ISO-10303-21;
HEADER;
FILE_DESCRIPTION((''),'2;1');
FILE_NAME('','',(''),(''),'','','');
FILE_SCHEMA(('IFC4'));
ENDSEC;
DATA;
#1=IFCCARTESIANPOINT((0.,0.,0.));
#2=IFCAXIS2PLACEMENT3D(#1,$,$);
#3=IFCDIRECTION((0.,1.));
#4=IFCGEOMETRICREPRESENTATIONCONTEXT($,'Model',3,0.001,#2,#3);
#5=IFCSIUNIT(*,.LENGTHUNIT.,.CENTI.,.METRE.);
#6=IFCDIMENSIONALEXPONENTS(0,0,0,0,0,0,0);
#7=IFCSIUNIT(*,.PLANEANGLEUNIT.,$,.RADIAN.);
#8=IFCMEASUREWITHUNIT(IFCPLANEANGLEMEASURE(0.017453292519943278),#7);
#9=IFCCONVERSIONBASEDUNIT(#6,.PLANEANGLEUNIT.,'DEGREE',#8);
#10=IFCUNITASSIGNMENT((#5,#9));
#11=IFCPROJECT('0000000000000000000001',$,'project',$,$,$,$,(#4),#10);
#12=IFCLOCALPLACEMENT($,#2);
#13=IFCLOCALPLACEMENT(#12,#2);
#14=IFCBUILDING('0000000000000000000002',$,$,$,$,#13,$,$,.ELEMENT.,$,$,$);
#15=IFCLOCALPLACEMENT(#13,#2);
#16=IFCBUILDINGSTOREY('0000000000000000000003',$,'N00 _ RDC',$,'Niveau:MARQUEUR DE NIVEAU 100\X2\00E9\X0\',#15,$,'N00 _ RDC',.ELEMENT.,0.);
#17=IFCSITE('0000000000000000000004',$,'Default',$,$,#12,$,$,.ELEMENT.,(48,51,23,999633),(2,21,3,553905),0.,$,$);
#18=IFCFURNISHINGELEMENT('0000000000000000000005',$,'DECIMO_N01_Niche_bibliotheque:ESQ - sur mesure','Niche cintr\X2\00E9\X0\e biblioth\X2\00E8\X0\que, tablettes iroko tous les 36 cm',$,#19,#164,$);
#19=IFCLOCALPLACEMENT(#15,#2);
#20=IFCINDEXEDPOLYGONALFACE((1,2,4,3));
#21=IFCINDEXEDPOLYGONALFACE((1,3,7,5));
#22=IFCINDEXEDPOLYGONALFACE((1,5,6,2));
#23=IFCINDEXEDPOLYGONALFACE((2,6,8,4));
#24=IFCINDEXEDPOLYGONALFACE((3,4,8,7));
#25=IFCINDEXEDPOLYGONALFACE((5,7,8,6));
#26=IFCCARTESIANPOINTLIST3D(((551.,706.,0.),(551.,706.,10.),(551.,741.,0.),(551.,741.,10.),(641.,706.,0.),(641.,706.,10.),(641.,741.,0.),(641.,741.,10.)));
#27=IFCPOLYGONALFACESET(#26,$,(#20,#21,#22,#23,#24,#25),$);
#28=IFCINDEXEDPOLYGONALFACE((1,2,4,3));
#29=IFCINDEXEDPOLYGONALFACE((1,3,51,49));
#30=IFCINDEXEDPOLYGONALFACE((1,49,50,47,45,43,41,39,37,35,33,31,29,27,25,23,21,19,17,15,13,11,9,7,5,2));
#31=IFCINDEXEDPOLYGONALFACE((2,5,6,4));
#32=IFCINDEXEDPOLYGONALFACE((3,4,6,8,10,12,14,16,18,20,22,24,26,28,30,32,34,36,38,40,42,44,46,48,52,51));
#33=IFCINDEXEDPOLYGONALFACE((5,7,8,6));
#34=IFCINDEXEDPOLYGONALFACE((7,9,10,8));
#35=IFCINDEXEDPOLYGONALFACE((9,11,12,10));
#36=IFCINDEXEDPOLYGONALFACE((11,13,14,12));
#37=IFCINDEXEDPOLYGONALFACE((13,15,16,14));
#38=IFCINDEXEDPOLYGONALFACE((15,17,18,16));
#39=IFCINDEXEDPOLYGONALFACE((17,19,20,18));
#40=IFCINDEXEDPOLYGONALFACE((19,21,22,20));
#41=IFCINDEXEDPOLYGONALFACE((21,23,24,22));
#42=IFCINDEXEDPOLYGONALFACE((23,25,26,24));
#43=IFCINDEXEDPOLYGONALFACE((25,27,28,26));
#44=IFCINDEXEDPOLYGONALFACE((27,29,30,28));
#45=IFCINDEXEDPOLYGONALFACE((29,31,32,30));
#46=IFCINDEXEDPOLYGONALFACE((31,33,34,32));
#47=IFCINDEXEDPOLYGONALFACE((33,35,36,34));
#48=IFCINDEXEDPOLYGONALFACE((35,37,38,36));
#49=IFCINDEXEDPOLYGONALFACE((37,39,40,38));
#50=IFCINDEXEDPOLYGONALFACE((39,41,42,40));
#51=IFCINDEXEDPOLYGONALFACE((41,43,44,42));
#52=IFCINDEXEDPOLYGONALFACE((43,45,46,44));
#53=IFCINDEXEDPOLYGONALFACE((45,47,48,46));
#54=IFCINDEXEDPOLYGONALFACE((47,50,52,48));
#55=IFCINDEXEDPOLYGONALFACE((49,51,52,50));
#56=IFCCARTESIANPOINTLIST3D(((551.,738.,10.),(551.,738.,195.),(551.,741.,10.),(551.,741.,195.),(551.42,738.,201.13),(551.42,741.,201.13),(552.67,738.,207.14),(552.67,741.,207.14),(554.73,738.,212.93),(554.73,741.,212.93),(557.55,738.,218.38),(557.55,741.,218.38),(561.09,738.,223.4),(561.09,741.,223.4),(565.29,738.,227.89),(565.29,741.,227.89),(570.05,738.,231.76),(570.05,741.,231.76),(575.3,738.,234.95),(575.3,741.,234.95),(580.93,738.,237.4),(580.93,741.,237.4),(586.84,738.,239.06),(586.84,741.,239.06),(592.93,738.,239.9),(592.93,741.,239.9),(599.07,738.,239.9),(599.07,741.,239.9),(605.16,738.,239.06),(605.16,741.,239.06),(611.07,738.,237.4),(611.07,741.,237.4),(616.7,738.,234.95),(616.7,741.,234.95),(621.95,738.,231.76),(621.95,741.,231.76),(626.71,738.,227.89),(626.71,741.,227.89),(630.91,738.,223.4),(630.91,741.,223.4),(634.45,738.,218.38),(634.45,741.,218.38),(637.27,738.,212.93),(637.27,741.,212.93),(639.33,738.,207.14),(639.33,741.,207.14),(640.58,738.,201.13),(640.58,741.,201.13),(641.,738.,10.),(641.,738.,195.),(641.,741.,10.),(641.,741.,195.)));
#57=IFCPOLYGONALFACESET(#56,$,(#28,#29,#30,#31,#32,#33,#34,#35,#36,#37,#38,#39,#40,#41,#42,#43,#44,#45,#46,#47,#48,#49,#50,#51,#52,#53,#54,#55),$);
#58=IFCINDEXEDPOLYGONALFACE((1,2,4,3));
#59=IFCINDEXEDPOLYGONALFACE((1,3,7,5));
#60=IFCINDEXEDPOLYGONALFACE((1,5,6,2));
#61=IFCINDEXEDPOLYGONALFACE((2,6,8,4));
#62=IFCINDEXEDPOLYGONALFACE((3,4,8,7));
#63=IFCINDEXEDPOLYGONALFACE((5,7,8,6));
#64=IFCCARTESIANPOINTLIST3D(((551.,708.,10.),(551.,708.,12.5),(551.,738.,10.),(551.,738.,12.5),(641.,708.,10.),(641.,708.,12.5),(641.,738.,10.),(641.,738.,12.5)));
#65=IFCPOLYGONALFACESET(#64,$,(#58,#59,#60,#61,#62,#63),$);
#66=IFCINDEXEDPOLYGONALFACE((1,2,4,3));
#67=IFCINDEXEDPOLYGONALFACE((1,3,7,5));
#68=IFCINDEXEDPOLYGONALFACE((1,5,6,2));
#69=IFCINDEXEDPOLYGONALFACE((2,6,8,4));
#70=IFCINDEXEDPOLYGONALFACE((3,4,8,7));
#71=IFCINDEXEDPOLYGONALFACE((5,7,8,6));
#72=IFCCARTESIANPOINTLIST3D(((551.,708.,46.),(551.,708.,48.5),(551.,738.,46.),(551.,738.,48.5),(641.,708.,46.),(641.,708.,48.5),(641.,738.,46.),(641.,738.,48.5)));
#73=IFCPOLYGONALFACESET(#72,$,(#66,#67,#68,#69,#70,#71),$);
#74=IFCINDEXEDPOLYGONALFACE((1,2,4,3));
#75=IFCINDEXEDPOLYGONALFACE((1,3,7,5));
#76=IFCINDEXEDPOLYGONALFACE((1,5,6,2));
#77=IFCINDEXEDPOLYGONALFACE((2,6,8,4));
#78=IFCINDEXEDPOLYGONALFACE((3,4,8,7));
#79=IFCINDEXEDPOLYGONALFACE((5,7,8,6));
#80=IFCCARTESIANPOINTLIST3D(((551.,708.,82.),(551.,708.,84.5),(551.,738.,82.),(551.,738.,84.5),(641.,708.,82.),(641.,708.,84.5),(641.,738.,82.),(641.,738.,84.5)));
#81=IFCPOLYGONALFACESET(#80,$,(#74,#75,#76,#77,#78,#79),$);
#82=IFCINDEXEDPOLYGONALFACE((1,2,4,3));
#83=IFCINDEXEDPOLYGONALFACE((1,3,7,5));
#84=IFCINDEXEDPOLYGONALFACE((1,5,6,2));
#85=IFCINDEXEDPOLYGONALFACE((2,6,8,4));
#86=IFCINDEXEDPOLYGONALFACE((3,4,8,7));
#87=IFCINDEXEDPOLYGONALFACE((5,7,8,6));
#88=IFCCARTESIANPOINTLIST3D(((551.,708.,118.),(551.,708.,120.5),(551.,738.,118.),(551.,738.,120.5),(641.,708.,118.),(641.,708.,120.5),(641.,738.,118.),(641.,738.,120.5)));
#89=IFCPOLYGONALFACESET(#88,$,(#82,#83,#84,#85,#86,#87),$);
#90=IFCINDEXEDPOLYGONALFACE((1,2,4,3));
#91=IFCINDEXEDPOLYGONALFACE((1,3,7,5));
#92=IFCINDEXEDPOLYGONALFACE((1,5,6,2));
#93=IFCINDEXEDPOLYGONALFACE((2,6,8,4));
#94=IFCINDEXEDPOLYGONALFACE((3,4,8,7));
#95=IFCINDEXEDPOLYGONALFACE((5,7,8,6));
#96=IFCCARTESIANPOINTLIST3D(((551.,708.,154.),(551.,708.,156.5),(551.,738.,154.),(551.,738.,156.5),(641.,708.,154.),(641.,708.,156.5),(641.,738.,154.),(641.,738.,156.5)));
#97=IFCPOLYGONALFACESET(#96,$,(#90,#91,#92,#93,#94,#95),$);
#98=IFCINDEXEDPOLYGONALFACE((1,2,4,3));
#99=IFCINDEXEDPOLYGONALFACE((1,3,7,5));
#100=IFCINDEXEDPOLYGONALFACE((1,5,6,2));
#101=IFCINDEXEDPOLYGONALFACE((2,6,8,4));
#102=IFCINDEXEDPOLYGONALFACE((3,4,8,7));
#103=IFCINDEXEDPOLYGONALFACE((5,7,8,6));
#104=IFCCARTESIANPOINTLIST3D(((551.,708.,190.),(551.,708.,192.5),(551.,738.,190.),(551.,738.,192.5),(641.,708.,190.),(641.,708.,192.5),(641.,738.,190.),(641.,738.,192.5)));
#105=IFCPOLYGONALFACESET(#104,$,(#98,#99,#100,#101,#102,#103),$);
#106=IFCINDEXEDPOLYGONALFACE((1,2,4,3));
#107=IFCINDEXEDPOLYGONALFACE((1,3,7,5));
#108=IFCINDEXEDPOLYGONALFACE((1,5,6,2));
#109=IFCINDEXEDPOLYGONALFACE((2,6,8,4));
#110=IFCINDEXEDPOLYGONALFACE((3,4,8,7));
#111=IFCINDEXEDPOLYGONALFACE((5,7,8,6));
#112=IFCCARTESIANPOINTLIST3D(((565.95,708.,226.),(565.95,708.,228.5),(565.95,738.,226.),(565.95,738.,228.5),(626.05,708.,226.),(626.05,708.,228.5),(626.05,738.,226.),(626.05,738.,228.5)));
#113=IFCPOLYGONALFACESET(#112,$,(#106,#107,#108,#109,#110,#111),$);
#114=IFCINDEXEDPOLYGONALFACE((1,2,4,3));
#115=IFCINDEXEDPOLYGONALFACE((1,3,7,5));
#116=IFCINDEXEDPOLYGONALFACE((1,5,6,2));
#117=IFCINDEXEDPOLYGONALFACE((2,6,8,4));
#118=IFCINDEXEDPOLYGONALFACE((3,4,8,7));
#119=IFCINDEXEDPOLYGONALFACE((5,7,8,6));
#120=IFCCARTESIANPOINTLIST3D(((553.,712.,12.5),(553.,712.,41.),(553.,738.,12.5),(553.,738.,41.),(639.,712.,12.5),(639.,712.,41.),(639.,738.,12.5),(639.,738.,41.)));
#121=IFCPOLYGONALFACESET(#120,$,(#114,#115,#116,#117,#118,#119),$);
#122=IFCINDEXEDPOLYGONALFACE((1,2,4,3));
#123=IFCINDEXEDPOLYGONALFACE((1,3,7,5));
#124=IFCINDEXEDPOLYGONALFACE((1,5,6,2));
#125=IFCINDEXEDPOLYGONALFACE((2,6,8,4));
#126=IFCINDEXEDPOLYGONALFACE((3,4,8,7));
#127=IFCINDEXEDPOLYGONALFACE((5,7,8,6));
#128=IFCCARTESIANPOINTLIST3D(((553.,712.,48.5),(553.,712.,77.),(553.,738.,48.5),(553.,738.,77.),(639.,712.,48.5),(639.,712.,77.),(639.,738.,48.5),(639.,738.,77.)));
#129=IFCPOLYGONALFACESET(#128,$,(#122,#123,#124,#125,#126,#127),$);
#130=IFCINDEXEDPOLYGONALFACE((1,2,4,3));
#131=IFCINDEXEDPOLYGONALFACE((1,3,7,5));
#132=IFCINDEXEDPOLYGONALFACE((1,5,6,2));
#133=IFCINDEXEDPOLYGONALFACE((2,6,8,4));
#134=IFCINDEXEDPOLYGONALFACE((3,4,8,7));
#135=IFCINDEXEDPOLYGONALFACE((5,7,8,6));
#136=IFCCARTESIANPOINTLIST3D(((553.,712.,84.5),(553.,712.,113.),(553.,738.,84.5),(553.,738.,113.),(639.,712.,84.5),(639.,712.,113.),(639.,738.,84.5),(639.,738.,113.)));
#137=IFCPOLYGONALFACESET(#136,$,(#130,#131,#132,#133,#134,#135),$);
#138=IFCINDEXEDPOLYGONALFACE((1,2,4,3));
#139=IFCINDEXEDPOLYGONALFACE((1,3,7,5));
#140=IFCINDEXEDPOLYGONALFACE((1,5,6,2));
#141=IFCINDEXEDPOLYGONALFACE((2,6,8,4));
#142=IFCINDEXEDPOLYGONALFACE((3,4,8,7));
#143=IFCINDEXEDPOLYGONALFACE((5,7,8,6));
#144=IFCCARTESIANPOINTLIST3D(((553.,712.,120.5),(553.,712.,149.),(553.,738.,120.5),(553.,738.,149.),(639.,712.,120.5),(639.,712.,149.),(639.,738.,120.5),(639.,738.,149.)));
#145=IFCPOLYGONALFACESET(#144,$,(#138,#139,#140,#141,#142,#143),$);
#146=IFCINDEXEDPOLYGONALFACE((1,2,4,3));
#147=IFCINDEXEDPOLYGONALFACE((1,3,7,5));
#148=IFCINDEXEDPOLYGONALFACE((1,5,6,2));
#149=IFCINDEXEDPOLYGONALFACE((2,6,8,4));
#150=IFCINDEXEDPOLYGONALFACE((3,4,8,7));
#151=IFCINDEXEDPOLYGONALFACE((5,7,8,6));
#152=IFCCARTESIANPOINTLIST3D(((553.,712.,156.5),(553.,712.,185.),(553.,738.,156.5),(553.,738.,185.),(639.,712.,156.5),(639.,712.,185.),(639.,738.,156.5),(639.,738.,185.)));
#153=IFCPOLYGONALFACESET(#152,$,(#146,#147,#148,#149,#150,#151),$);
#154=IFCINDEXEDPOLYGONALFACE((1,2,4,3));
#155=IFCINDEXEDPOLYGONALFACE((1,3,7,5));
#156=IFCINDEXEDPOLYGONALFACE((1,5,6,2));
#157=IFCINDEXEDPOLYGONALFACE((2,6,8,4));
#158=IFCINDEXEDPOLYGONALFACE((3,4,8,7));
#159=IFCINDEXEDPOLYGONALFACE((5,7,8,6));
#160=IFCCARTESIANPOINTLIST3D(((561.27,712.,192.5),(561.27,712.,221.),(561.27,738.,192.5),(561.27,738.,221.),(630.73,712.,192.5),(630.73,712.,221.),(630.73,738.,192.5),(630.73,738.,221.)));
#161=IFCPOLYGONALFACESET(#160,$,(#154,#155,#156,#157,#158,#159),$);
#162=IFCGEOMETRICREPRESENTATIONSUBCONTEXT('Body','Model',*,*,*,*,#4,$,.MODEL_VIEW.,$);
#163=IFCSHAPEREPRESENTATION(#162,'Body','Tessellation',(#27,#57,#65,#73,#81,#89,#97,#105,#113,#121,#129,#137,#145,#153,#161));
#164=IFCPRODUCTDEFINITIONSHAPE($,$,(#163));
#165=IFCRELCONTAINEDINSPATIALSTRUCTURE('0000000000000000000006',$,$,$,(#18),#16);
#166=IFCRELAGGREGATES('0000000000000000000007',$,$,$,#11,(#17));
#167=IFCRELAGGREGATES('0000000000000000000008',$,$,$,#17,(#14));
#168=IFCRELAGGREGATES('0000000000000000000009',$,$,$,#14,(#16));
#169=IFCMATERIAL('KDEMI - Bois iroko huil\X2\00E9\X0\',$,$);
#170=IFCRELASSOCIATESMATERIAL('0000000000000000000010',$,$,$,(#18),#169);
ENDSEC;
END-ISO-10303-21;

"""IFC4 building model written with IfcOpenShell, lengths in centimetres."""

from ifc_helpers import new_model, entity, si_unit, converted_unit, direction, frame, frame_2d, origin, origin_with_axes, place, context, subcontext, project, spatial, polyline, rectangle, outline, extrude, material, element, save


model = new_model("IFC4")

# Units and contexts
model_context = context("Model", 3, precision=0.001, world=origin(), true_north=direction((0.0, 1.0)))
body_context = subcontext(model_context, "Body", "Model", "MODEL_VIEW")
ifc_project = project(units=[si_unit("LENGTHUNIT", "METRE", prefix="CENTI"), converted_unit("PLANEANGLEUNIT", "DEGREE", entity("IfcPlaneAngleMeasure", 0.017453292519943278), si_unit("PLANEANGLEUNIT", "RADIAN"), dimensions=[0, 0, 0, 0, 0, 0, 0])], contexts=[model_context])

# Site, building, storey
site_placement = place(None, origin())
site = spatial("IfcSite", under=ifc_project, at=site_placement, Name="Default", CompositionType="ELEMENT", RefLatitude=(48, 51, 23, 999633), RefLongitude=(2, 21, 3, 553905), RefElevation=0.0)
building_placement = place(site_placement, origin())
building = spatial("IfcBuilding", under=site, at=building_placement, CompositionType="ELEMENT")
storey_placement = place(building_placement, origin())
storey = spatial("IfcBuildingStorey", under=building, at=storey_placement, Name="N00 _ RDC", ObjectType="Niveau:MARQUEUR DE NIVEAU 100é", LongName="N00 _ RDC", CompositionType="ELEMENT", Elevation=0.0)

# Furnishing element
ifc_material_1 = material(Name="KDEMI - Bois iroko huilé")
furnishing_1_placement = place(storey_placement, origin_with_axes())
element("IfcFurnishingElement", 1, at=furnishing_1_placement, inside=storey, material=ifc_material_1, Name="DECIMO_N01_Niche_bibliotheque:ESQ - sur mesure", Description="Niche cintrée bibliothèque, tablettes iroko tous les 36 cm", context=body_context, shape_type="SweptSolid", body=[
    extrude(rectangle(XDim=90.0, YDim=35.0, at=frame_2d((596.0, 723.5))), origin(), (0.0, 0.0, 1.0), 10.0),
    extrude(outline(polyline([(551.0, 10.0), (641.0, 10.0), (641.0, 195.0), (640.58, 201.13), (639.33, 207.14), (637.27, 212.93), (634.45, 218.38), (630.91, 223.4), (626.71, 227.89), (621.95, 231.76), (616.7, 234.95), (611.07, 237.4), (605.16, 239.06), (599.07, 239.9), (592.93, 239.9), (586.84, 239.06), (580.93, 237.4), (575.3, 234.95), (570.05, 231.76), (565.29, 227.89), (561.09, 223.4), (557.55, 218.38), (554.73, 212.93), (552.67, 207.14), (551.42, 201.13), (551.0, 195.0), (551.0, 10.0)])), frame((0.0, 741.0, 0.0), z_axis=(0.0, -1.0, 0.0), x_axis=(1.0, 0.0, 0.0)), (0.0, 0.0, 1.0), 3.0),
    extrude(rectangle(XDim=90.0, YDim=30.0, at=frame_2d((596.0, 723.0))), frame((0.0, 0.0, 10.0)), (0.0, 0.0, 1.0), 2.5),
    extrude(rectangle(XDim=90.0, YDim=30.0, at=frame_2d((596.0, 723.0))), frame((0.0, 0.0, 46.0)), (0.0, 0.0, 1.0), 2.5),
    extrude(rectangle(XDim=90.0, YDim=30.0, at=frame_2d((596.0, 723.0))), frame((0.0, 0.0, 82.0)), (0.0, 0.0, 1.0), 2.5),
    extrude(rectangle(XDim=90.0, YDim=30.0, at=frame_2d((596.0, 723.0))), frame((0.0, 0.0, 118.0)), (0.0, 0.0, 1.0), 2.5),
    extrude(rectangle(XDim=90.0, YDim=30.0, at=frame_2d((596.0, 723.0))), frame((0.0, 0.0, 154.0)), (0.0, 0.0, 1.0), 2.5),
    extrude(rectangle(XDim=90.0, YDim=30.0, at=frame_2d((596.0, 723.0))), frame((0.0, 0.0, 190.0)), (0.0, 0.0, 1.0), 2.5),
    extrude(rectangle(XDim=60.09, YDim=30.0, at=frame_2d((596.0, 723.0))), frame((0.0, 0.0, 226.0)), (0.0, 0.0, 1.0), 2.5),
    extrude(rectangle(XDim=86.0, YDim=26.0, at=frame_2d((596.0, 725.0))), frame((0.0, 0.0, 12.5)), (0.0, 0.0, 1.0), 28.5),
    extrude(rectangle(XDim=86.0, YDim=26.0, at=frame_2d((596.0, 725.0))), frame((0.0, 0.0, 48.5)), (0.0, 0.0, 1.0), 28.5),
    extrude(rectangle(XDim=86.0, YDim=26.0, at=frame_2d((596.0, 725.0))), frame((0.0, 0.0, 84.5)), (0.0, 0.0, 1.0), 28.5),
    extrude(rectangle(XDim=86.0, YDim=26.0, at=frame_2d((596.0, 725.0))), frame((0.0, 0.0, 120.5)), (0.0, 0.0, 1.0), 28.5),
    extrude(rectangle(XDim=86.0, YDim=26.0, at=frame_2d((596.0, 725.0))), frame((0.0, 0.0, 156.5)), (0.0, 0.0, 1.0), 28.5),
    extrude(rectangle(XDim=69.46, YDim=26.0, at=frame_2d((596.0, 725.0))), frame((0.0, 0.0, 192.5)), (0.0, 0.0, 1.0), 28.5),
])

save(model, "model.ifc")
